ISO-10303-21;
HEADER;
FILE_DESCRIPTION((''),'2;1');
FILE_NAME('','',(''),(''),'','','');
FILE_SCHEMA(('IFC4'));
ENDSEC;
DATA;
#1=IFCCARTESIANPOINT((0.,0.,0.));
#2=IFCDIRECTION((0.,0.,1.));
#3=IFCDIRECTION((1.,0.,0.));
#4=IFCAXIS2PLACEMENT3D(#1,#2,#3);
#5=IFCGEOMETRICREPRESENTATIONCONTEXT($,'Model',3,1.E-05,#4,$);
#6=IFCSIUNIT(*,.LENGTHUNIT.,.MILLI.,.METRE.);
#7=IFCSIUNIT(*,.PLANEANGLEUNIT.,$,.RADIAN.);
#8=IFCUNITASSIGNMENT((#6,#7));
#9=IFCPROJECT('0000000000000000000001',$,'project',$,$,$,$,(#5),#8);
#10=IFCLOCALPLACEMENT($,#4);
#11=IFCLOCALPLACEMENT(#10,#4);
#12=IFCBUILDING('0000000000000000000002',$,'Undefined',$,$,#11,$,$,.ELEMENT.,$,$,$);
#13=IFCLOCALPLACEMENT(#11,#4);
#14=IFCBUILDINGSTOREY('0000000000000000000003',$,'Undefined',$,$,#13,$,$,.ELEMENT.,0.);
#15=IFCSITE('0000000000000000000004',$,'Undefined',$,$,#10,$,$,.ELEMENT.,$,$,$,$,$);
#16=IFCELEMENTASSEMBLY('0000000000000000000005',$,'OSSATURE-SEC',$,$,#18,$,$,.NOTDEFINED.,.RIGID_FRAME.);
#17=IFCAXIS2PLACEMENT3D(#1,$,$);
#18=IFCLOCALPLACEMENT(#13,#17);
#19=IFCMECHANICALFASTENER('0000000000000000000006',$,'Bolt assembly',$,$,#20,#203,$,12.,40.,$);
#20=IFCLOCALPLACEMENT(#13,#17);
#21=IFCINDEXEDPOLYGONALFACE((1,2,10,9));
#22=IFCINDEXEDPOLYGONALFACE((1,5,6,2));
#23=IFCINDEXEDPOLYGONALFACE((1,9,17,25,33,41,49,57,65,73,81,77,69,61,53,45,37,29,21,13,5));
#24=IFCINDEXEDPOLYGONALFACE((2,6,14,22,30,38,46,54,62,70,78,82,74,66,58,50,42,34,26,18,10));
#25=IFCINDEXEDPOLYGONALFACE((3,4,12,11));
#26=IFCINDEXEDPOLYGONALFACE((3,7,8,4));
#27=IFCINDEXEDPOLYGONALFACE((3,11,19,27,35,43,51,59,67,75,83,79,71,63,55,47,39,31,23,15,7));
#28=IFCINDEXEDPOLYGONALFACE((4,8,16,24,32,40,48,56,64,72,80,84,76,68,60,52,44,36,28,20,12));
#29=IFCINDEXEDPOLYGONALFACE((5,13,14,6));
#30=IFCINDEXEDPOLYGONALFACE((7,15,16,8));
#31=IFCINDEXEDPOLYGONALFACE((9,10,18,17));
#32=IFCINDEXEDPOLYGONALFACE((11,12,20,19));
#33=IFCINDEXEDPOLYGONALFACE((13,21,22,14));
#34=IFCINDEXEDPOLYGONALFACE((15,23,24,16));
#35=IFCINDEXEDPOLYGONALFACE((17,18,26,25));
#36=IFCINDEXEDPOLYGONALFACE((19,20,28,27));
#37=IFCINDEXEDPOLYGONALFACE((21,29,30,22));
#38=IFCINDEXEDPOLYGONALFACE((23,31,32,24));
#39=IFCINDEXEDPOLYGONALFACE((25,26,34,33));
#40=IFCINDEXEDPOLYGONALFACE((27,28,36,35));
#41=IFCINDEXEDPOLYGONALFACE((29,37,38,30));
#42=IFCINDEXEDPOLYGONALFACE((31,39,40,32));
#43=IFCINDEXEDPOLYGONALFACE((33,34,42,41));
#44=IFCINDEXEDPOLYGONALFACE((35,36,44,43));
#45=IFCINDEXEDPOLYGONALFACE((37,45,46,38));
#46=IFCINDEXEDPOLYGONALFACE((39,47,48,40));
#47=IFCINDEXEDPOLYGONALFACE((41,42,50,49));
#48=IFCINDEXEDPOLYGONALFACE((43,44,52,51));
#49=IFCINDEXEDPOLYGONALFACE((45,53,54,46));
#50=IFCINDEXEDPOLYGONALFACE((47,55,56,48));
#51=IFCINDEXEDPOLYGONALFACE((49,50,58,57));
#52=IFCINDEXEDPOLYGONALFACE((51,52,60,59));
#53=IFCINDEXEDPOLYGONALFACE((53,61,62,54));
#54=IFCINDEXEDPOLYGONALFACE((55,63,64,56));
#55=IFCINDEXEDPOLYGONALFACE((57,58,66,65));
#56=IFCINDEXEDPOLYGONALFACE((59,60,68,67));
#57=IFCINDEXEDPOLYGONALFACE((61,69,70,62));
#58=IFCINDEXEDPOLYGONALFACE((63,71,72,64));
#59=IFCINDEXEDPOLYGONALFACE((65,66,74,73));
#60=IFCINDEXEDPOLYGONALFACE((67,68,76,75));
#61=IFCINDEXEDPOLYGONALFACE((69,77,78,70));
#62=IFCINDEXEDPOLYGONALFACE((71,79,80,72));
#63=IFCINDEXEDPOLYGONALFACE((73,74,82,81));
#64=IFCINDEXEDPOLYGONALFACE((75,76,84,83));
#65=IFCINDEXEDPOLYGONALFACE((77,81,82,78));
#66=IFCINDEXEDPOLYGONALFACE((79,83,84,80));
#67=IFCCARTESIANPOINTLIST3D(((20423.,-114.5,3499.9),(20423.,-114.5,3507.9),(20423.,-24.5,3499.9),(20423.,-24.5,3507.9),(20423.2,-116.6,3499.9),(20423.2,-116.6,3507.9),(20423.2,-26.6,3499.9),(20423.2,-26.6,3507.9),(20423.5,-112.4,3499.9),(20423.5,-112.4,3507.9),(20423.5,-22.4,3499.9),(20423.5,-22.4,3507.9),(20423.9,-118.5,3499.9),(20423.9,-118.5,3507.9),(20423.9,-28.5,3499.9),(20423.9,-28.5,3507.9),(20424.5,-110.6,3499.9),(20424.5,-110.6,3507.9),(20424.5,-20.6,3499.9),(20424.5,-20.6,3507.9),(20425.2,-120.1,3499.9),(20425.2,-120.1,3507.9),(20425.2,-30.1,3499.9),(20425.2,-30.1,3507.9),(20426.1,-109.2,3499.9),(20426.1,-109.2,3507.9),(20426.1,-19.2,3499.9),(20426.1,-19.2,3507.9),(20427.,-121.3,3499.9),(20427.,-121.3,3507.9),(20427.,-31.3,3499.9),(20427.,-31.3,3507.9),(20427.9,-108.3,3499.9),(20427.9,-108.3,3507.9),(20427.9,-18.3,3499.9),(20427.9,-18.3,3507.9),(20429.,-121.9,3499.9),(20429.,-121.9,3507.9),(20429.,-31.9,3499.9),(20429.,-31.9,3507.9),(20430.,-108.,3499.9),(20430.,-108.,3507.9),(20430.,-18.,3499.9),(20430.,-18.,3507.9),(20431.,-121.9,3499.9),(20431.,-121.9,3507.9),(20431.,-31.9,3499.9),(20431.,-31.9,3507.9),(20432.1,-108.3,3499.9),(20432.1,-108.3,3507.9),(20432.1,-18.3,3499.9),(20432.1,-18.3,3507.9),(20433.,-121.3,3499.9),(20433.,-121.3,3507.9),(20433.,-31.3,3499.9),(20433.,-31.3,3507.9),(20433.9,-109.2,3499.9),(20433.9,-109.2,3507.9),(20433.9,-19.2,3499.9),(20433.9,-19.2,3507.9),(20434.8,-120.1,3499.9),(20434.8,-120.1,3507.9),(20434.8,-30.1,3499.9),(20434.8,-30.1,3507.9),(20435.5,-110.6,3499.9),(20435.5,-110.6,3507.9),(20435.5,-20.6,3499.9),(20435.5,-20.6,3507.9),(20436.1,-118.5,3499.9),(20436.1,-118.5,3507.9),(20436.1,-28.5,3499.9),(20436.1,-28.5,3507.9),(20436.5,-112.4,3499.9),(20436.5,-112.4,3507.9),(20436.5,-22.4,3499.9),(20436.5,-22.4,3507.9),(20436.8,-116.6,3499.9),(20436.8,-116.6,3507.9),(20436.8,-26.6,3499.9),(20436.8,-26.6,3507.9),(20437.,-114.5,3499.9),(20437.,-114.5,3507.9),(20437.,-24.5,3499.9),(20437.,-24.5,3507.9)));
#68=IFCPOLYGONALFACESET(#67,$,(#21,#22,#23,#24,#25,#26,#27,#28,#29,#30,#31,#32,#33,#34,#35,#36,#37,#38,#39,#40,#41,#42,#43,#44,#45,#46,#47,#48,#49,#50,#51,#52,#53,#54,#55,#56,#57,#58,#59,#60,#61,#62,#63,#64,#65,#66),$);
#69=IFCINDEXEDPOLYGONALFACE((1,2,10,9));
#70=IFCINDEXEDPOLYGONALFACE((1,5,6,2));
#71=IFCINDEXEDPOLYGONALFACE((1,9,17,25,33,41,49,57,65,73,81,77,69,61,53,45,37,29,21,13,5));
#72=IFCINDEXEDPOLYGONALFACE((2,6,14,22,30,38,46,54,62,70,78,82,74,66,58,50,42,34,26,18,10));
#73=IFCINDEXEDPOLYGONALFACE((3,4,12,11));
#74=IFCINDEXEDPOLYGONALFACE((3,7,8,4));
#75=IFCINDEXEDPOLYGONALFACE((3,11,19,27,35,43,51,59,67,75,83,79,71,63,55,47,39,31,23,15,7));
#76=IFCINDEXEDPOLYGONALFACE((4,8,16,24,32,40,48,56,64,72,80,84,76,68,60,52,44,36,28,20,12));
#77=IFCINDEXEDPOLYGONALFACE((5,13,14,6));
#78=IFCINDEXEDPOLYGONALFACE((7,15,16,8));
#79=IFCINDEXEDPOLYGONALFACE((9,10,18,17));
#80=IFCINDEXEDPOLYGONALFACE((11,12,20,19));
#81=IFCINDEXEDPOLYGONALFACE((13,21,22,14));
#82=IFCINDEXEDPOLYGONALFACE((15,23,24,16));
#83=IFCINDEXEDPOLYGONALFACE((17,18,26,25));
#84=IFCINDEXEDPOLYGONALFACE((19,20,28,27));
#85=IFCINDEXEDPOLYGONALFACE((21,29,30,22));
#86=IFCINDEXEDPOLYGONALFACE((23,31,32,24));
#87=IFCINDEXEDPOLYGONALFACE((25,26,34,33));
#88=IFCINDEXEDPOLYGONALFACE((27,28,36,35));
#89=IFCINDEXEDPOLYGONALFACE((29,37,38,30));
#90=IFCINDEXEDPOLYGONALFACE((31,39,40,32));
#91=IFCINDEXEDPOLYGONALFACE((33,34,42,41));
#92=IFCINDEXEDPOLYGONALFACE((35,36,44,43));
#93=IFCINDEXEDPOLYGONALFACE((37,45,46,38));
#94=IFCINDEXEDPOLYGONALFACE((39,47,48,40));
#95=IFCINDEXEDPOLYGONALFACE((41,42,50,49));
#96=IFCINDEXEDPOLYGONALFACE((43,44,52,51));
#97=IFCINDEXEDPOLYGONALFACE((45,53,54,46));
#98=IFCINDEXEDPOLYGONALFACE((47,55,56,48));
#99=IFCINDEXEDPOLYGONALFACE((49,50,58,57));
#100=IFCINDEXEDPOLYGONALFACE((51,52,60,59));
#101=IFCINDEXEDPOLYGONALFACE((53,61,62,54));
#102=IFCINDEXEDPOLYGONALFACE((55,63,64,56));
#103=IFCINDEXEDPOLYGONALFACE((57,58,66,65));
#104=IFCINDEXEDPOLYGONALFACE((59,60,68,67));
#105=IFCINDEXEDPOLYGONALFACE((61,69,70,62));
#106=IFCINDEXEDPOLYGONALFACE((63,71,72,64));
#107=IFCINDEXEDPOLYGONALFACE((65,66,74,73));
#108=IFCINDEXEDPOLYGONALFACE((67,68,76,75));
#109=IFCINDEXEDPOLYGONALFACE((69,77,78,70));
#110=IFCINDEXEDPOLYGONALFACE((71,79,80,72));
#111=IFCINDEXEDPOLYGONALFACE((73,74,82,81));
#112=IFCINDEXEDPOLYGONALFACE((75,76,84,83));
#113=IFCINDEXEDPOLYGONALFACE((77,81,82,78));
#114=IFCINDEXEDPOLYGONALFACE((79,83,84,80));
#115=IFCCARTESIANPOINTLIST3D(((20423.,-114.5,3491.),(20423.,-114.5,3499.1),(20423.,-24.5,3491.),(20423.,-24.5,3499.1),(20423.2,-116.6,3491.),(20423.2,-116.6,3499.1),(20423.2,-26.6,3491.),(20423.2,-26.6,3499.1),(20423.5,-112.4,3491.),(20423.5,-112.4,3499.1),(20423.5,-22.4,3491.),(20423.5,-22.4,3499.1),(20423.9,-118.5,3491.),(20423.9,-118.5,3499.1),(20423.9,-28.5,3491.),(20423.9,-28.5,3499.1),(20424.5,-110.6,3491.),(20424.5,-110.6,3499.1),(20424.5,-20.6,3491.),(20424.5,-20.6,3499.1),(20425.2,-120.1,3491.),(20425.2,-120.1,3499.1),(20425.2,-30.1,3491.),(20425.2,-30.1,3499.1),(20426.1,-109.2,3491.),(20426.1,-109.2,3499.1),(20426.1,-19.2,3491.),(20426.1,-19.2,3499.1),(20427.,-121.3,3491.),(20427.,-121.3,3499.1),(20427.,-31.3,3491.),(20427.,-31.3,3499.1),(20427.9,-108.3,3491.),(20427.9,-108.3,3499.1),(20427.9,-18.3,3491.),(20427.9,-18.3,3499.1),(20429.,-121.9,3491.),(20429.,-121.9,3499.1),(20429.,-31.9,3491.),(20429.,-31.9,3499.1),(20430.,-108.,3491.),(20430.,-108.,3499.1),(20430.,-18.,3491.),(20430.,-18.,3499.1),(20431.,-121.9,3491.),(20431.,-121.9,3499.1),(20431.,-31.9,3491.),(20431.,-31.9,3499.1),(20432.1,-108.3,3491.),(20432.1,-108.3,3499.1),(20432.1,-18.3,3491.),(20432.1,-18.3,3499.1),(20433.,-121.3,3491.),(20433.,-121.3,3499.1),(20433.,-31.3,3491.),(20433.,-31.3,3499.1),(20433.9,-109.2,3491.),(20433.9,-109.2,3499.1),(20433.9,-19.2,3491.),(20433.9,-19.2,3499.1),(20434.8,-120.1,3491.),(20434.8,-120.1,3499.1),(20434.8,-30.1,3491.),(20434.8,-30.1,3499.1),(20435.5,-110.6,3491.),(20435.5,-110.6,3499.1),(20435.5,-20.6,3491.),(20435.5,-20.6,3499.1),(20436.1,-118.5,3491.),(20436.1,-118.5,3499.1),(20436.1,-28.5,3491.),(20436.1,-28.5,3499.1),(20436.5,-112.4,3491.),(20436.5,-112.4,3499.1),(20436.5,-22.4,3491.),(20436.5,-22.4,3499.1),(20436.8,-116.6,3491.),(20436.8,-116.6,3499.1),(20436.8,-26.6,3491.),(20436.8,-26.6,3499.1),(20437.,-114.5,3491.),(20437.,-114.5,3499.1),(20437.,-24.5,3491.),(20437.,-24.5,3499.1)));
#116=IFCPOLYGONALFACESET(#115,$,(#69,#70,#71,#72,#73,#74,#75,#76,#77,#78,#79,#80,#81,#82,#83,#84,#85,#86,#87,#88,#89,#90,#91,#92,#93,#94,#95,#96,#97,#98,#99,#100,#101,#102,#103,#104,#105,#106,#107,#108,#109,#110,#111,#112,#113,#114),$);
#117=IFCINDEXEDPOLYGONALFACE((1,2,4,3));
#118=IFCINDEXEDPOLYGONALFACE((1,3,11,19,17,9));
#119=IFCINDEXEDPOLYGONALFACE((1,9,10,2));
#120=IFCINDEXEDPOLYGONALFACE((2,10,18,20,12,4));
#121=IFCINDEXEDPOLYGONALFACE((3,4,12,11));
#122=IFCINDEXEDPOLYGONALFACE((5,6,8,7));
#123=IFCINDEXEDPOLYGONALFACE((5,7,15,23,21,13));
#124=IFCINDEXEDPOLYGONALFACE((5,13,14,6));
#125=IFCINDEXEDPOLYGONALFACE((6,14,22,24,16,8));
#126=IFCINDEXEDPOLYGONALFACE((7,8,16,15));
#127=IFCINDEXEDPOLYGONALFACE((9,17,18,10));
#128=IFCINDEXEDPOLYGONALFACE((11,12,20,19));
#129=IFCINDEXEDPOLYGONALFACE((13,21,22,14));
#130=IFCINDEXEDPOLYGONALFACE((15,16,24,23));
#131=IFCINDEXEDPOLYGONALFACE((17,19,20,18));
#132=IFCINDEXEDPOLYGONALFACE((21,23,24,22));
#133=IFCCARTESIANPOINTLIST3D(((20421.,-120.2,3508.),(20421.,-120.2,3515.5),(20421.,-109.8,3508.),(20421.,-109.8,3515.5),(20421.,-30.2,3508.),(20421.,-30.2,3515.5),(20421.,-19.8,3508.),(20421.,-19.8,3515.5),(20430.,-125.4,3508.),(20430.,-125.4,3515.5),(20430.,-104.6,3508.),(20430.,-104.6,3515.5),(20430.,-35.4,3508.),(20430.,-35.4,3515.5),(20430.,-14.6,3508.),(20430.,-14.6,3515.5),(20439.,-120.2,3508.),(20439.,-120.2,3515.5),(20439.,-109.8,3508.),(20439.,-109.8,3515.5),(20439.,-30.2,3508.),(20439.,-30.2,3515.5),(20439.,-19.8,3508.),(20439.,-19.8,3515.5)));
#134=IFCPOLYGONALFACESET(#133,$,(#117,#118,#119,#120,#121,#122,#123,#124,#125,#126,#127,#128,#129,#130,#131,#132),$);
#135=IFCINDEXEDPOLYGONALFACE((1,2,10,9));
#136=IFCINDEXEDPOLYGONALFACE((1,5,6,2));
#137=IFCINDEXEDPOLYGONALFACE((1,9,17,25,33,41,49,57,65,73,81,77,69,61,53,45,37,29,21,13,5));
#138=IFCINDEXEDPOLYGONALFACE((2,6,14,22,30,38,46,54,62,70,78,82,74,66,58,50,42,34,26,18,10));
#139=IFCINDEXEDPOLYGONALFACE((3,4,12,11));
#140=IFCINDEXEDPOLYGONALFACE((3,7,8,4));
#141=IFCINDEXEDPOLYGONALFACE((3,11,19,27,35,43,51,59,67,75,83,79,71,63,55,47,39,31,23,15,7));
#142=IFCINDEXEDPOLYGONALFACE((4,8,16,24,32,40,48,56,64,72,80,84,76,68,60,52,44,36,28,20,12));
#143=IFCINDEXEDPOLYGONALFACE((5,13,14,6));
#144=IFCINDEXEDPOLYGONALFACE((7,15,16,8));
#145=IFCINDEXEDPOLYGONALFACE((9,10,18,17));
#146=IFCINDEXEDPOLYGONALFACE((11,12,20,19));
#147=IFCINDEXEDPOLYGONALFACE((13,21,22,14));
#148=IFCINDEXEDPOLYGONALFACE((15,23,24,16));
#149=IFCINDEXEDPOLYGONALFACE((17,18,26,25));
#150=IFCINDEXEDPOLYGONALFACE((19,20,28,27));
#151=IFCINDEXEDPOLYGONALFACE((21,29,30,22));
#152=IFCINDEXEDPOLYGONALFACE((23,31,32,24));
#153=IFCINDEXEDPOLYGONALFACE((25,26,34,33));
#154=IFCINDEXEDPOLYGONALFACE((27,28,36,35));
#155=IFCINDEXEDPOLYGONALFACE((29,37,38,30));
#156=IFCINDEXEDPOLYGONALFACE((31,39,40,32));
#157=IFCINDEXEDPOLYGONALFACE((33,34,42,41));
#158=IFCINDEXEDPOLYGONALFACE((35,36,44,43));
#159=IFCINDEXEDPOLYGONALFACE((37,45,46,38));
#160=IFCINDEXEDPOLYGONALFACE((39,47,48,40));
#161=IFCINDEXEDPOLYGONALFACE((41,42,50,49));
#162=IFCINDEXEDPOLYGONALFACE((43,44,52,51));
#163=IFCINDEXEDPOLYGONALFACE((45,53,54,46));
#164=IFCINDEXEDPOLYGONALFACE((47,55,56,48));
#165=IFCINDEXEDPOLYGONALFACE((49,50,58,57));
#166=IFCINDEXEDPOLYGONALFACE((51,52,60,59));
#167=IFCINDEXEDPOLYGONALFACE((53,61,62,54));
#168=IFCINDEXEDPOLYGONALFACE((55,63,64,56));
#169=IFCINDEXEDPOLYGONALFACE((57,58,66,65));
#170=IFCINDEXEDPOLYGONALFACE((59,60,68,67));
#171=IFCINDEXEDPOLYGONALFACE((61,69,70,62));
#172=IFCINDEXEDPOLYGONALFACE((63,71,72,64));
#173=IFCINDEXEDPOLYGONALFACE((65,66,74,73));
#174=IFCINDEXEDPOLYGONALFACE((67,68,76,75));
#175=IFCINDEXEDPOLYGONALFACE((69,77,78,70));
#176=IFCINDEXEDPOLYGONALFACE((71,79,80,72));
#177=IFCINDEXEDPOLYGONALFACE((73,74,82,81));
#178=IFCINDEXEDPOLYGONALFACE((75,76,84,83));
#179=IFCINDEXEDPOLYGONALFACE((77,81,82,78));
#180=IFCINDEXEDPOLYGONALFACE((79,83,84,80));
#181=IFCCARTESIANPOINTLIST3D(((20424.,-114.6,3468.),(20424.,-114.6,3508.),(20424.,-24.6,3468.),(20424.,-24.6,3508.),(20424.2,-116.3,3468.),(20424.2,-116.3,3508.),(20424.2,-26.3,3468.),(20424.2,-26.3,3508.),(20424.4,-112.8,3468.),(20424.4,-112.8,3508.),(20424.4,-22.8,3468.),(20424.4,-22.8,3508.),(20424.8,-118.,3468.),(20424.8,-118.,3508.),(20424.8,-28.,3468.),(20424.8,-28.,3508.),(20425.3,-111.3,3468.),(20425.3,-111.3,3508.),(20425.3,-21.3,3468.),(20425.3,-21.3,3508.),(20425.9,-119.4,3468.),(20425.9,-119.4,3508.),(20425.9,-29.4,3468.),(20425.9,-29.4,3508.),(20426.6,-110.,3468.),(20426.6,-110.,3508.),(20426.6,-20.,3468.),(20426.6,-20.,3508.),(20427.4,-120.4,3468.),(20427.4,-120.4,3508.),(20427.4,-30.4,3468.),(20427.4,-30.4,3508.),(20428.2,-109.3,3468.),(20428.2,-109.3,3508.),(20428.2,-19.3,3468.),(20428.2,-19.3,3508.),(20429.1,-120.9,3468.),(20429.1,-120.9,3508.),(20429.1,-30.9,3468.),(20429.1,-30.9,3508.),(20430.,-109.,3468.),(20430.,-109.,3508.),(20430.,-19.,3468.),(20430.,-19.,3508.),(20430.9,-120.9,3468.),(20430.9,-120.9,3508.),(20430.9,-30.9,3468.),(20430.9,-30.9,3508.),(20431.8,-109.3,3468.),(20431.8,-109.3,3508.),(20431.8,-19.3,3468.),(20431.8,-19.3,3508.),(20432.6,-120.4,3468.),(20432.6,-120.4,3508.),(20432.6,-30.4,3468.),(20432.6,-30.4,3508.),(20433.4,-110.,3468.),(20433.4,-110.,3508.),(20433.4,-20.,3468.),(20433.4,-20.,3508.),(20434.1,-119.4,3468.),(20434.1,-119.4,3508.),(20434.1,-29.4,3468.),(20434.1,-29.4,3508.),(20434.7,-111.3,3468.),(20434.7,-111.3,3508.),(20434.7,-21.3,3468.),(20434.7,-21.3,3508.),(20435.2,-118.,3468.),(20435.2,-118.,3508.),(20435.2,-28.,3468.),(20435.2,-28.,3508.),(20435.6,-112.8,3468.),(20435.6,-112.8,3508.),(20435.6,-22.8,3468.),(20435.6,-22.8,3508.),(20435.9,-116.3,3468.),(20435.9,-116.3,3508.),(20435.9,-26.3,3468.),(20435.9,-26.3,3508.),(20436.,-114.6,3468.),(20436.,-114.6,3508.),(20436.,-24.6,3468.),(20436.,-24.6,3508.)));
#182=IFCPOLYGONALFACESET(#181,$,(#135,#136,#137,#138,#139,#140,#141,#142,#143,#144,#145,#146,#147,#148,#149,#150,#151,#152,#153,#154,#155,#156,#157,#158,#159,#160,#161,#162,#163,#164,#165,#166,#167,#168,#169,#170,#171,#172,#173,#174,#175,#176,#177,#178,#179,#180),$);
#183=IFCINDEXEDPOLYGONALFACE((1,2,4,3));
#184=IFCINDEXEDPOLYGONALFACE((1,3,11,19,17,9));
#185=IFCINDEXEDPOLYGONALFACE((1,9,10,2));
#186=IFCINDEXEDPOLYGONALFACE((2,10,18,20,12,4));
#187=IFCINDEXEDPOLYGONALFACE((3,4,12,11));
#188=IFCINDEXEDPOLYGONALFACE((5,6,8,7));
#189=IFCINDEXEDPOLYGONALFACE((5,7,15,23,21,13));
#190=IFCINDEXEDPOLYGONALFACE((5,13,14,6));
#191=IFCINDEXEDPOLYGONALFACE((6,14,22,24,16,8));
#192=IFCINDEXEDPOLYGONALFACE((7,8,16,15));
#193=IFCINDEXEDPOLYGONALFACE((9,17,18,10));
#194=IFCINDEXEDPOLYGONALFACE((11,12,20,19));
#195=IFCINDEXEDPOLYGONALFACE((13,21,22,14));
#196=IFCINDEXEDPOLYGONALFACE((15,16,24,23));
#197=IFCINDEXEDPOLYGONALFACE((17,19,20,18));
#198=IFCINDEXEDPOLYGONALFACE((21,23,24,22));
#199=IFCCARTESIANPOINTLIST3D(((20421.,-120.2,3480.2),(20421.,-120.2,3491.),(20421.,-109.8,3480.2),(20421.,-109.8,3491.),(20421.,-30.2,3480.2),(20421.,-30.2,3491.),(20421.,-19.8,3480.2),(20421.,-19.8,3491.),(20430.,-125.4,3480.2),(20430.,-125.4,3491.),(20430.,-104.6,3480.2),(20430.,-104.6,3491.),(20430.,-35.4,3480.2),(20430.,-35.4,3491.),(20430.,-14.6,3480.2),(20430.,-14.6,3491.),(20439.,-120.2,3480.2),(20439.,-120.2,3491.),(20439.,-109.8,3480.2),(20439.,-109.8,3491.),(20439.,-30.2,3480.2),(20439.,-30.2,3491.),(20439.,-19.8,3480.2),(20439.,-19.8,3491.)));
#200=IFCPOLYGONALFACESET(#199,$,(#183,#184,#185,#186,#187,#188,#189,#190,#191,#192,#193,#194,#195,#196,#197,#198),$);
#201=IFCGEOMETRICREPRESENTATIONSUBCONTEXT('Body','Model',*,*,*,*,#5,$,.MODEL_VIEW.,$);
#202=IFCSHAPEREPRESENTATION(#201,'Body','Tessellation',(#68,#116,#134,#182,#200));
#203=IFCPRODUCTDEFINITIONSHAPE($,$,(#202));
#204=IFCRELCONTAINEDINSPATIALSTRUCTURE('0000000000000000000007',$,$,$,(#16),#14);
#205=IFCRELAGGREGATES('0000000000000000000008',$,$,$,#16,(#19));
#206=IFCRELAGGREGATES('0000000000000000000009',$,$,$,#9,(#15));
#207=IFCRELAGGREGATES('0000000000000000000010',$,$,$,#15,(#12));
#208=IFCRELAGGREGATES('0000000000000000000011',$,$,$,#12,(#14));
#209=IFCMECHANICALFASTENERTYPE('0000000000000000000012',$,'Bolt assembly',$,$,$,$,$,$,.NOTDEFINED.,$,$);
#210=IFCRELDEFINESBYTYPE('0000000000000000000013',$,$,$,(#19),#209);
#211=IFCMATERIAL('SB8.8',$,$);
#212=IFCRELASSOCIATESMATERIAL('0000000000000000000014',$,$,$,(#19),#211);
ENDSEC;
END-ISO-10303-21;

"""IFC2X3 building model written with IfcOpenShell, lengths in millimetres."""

from ifc_helpers import new_model, si_unit, frame, origin_with_axes, origin_2d_with_axis, place, context, subcontext, project, spatial, polyline, circle, outline, extrude, source, transform, mapped, material, type_object, element, aggregate, save


model = new_model("IFC2X3")

# Units and contexts
model_context = context("Model", 3, precision=1e-05, world=origin_with_axes())
body_context = subcontext(model_context, "Body", "Model", "MODEL_VIEW")
ifc_project = project(units=[si_unit("LENGTHUNIT", "METRE", prefix="MILLI"), si_unit("PLANEANGLEUNIT", "RADIAN")], contexts=[model_context])

# Site, building, storey
site_placement = place(None, origin_with_axes())
site = spatial("IfcSite", under=ifc_project, at=site_placement, Name="Undefined", CompositionType="ELEMENT")
building_placement = place(site_placement, origin_with_axes())
building = spatial("IfcBuilding", under=site, at=building_placement, Name="Undefined", CompositionType="ELEMENT")
storey_placement = place(building_placement, origin_with_axes())
storey = spatial("IfcBuildingStorey", under=building, at=storey_placement, Name="Undefined", CompositionType="ELEMENT", Elevation=0.0)

# Element assembly
assembly_1_placement = place(storey_placement, origin_with_axes())
assembly_1 = element("IfcElementAssembly", 1, at=assembly_1_placement, inside=storey, Name="OSSATURE-SEC", AssemblyPlace="NOTDEFINED", PredefinedType="RIGID_FRAME")

# Mechanical fastener
ifc_material_1 = material(Name="SB8.8")
mechanical_fastener_type = type_object("IfcMechanicalFastenerType", Name="Bolt assembly")
shared_shape_1 = source(origin_with_axes(), body_context, "Body", "SweptSolid", [
    extrude(circle(Radius=7.0, at=origin_2d_with_axis()), frame((0.0, -6.9, 0.0), z_axis=(0.0, 1.0, 0.0), x_axis=(1.0, 0.0, 0.0)), (0.0, 0.0, 1.0), 8.0),
    extrude(circle(Radius=7.0, at=origin_2d_with_axis()), frame((0.0, 1.9, 0.0), z_axis=(0.0, 1.0, 0.0), x_axis=(1.0, 0.0, 0.0)), (0.0, 0.0, 1.0), 8.1),
    extrude(outline(polyline([(10.4, 0.0), (5.2, 9.0), (-5.2, 9.0), (-10.4, 0.0), (-5.2, -9.0), (5.2, -9.0), (10.4, 0.0)])), frame((0.0, -14.5, 0.0), z_axis=(0.0, 1.0, 0.0), x_axis=(1.0, 0.0, 0.0)), (0.0, 0.0, 1.0), 7.5),
    extrude(circle(Radius=6.0, at=origin_2d_with_axis()), frame((0.0, -7.0, 0.0), z_axis=(0.0, 1.0, 0.0), x_axis=(1.0, 0.0, 0.0)), (0.0, 0.0, 1.0), 40.0),
    extrude(outline(polyline([(10.4, 0.0), (5.2, 9.0), (-5.2, 9.0), (-10.4, 0.0), (-5.2, -9.0), (5.2, -9.0), (10.4, 0.0)])), frame((0.0, 10.0, 0.0), z_axis=(0.0, 1.0, 0.0), x_axis=(1.0, 0.0, 0.0)), (0.0, 0.0, 1.0), 10.8),
])
mechanical_fastener_1_placement = place(assembly_1_placement, frame((20430.0, -115.0, 3501.0), z_axis=(-1.0, 0.0, 0.0), x_axis=(0.0, 1.0, 0.0)))
mechanical_fastener_1 = element("IfcMechanicalFastener", 2, at=mechanical_fastener_1_placement, type_object=mechanical_fastener_type, material=ifc_material_1, Name="Bolt assembly", NominalDiameter=12.0, NominalLength=40.0, context=body_context, shape_type="MappedRepresentation", body=[
    mapped(shared_shape_1, transform((0.0, 0.0, 0.0))),
    mapped(shared_shape_1, transform((90.0, 0.0, 0.0))),
])
aggregate(assembly_1, [mechanical_fastener_1])

save(model, "model.ifc")
